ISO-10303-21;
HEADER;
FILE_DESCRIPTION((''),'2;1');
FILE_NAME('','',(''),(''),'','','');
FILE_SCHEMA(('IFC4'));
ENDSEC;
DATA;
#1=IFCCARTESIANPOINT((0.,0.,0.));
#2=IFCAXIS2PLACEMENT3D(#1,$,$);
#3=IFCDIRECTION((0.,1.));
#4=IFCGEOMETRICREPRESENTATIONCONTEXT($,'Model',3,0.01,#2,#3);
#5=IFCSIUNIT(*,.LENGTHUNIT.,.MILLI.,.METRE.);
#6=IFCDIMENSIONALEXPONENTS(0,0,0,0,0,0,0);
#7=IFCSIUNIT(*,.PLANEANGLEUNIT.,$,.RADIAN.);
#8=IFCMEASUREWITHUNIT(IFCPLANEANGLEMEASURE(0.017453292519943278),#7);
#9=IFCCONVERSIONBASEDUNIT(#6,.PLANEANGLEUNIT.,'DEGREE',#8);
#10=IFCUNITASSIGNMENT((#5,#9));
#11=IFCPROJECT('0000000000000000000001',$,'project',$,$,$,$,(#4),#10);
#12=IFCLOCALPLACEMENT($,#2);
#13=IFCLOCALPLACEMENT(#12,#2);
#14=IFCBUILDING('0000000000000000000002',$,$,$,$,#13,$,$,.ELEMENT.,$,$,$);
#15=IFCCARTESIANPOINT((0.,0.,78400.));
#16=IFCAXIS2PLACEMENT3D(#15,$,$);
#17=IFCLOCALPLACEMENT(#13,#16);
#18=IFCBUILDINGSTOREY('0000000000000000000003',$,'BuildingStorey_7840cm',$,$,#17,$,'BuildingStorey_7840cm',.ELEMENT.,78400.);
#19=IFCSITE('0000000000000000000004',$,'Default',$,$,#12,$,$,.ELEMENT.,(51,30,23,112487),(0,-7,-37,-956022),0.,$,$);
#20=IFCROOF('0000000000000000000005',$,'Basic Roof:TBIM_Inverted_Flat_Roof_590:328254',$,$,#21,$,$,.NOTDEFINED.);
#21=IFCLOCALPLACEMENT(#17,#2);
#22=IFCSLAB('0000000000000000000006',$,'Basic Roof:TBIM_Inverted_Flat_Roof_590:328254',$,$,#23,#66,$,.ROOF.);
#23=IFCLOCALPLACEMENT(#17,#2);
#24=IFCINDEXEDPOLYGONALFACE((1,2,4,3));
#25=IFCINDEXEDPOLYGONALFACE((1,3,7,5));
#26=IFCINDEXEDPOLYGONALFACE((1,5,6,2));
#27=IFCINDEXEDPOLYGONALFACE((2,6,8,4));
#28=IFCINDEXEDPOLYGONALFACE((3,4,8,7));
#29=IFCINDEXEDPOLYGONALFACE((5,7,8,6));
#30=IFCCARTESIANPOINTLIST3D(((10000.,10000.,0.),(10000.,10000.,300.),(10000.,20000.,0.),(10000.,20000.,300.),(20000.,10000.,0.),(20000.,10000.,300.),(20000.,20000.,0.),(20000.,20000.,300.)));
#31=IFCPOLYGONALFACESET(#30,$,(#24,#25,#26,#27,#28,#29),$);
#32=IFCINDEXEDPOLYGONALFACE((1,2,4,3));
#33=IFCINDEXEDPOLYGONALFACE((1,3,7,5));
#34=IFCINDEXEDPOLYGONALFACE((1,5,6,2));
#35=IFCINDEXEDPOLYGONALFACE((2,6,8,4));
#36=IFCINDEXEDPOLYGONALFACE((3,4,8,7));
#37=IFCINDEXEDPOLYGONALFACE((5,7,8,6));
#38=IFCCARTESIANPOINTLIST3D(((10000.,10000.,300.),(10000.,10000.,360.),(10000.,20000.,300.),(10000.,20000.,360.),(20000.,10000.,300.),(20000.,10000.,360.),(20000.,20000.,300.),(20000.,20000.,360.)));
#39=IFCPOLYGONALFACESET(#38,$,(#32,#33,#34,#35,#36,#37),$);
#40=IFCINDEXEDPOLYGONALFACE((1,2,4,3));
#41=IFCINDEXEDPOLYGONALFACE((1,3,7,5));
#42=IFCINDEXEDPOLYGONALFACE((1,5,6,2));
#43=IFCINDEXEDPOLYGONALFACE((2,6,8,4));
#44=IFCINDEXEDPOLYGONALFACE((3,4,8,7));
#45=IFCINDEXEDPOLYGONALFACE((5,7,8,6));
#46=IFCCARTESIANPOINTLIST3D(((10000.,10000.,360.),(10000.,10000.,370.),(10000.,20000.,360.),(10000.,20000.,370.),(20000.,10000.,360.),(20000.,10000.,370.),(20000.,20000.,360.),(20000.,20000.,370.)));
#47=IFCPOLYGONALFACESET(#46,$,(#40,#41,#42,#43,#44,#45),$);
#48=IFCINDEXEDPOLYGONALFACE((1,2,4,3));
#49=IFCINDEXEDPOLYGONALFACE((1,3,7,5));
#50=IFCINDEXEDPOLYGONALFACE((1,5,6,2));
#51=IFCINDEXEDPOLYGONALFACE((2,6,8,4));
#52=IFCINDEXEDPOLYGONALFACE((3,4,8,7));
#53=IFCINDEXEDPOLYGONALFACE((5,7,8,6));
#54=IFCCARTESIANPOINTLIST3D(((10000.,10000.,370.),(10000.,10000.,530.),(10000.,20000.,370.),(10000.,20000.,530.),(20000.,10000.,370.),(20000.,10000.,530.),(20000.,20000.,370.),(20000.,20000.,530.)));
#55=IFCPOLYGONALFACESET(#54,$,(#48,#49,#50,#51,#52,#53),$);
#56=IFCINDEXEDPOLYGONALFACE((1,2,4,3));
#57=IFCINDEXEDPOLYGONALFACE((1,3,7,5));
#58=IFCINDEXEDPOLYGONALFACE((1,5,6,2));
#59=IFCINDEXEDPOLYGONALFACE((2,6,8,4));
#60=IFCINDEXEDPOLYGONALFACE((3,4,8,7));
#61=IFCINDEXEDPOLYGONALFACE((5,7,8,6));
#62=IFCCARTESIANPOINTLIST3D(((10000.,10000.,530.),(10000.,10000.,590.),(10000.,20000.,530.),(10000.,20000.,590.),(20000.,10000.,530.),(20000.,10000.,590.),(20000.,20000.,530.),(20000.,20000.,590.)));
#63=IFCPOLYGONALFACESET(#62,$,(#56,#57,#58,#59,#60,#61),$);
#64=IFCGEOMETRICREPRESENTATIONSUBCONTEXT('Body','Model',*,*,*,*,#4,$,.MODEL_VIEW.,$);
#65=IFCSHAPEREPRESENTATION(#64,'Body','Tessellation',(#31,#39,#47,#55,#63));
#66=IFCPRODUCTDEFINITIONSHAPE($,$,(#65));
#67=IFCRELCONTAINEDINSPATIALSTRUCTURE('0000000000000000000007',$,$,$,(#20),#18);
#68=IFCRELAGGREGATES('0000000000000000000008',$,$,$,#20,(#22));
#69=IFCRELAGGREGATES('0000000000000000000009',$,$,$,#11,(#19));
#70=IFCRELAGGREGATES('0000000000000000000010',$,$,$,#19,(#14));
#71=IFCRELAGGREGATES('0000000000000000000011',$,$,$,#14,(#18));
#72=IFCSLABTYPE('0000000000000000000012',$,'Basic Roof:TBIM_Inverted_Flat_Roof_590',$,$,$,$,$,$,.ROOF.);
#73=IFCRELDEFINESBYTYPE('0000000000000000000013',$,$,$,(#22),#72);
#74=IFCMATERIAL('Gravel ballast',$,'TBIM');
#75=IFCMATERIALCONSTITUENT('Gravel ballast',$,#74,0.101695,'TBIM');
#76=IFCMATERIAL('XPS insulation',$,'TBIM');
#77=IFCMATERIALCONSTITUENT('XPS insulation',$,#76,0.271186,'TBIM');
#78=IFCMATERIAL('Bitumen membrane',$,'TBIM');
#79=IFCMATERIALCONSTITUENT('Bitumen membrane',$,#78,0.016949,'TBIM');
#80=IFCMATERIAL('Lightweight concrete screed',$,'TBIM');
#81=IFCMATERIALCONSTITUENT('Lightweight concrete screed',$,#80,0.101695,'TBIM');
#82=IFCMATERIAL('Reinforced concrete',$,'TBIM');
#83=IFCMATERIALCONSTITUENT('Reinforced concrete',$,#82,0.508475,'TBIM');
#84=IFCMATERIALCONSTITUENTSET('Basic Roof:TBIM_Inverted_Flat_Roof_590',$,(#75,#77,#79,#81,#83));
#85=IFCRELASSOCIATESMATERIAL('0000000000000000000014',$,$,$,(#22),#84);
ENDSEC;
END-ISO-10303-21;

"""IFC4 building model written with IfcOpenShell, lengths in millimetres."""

from ifc_helpers import new_model, entity, si_unit, converted_unit, direction, frame, origin, place, context, subcontext, project, spatial, indexed_curve, outline, extrude, material, constituent, constituent_set, type_object, element, aggregate, save


model = new_model("IFC4")

# Units and contexts
model_context = context("Model", 3, precision=0.01, world=origin(), true_north=direction((0.0, 1.0)))
body_context = subcontext(model_context, "Body", "Model", "MODEL_VIEW")
ifc_project = project(units=[si_unit("LENGTHUNIT", "METRE", prefix="MILLI"), converted_unit("PLANEANGLEUNIT", "DEGREE", entity("IfcPlaneAngleMeasure", 0.017453292519943278), si_unit("PLANEANGLEUNIT", "RADIAN"), dimensions=[0, 0, 0, 0, 0, 0, 0])], contexts=[model_context])

# Site, building, storey
site_placement = place(None, origin())
site = spatial("IfcSite", under=ifc_project, at=site_placement, Name="Default", CompositionType="ELEMENT", RefLatitude=(51, 30, 23, 112487), RefLongitude=(0, -7, -37, -956022), RefElevation=0.0)
building_placement = place(site_placement, origin())
building = spatial("IfcBuilding", under=site, at=building_placement, CompositionType="ELEMENT")
storey_placement = place(building_placement, frame((0.0, 0.0, 78400.0)))
storey = spatial("IfcBuildingStorey", under=building, at=storey_placement, Name="BuildingStorey_7840cm", LongName="BuildingStorey_7840cm", CompositionType="ELEMENT", Elevation=78400.0)

# Roof, slab
roof_placement = place(storey_placement, frame((10000.0, 10000.0, 0.0)))
roof = element("IfcRoof", 1, at=roof_placement, inside=storey, Name="Basic Roof:TBIM_Inverted_Flat_Roof_590:328254", PredefinedType="NOTDEFINED")
ifc_material_1 = material(Name="Gravel ballast", Category="TBIM")
ifc_constituent_1 = constituent(ifc_material_1, Name="Gravel ballast", Category="TBIM", fraction=0.101695)
ifc_material_2 = material(Name="XPS insulation", Category="TBIM")
ifc_constituent_2 = constituent(ifc_material_2, Name="XPS insulation", Category="TBIM", fraction=0.271186)
ifc_material_3 = material(Name="Bitumen membrane", Category="TBIM")
ifc_constituent_3 = constituent(ifc_material_3, Name="Bitumen membrane", Category="TBIM", fraction=0.016949)
ifc_material_4 = material(Name="Lightweight concrete screed", Category="TBIM")
ifc_constituent_4 = constituent(ifc_material_4, Name="Lightweight concrete screed", Category="TBIM", fraction=0.101695)
ifc_material_5 = material(Name="Reinforced concrete", Category="TBIM")
ifc_constituent_5 = constituent(ifc_material_5, Name="Reinforced concrete", Category="TBIM", fraction=0.508475)
ifc_constituent_set = constituent_set(constituents=[ifc_constituent_1, ifc_constituent_2, ifc_constituent_3, ifc_constituent_4, ifc_constituent_5], Name="Basic Roof:TBIM_Inverted_Flat_Roof_590")
slab_type = type_object("IfcSlabType", Name="Basic Roof:TBIM_Inverted_Flat_Roof_590", PredefinedType="ROOF")
slab_placement = place(roof_placement, origin())
slab = element("IfcSlab", 2, at=slab_placement, type_object=slab_type, material=ifc_constituent_set, Name="Basic Roof:TBIM_Inverted_Flat_Roof_590:328254", PredefinedType="ROOF", context=body_context, shape_type="SweptSolid", body=[
    extrude(outline(indexed_curve([(-5000.0, 5000.0), (-5000.0, -5000.0), (5000.0, -5000.0), (5000.0, 5000.0), (-5000.0, 5000.0)], self_intersect=False)), frame((5000.0, 5000.0, 0.0)), (0.0, 0.0, 1.0), 300.0),
    extrude(outline(indexed_curve([(-5000.0, 5000.0), (-5000.0, -5000.0), (5000.0, -5000.0), (5000.0, 5000.0), (-5000.0, 5000.0)], self_intersect=False)), frame((5000.0, 5000.0, 300.0)), (0.0, 0.0, 1.0), 60.0),
    extrude(outline(indexed_curve([(-5000.0, 5000.0), (-5000.0, -5000.0), (5000.0, -5000.0), (5000.0, 5000.0), (-5000.0, 5000.0)], self_intersect=False)), frame((5000.0, 5000.0, 360.0)), (0.0, 0.0, 1.0), 10.0),
    extrude(outline(indexed_curve([(-5000.0, 5000.0), (-5000.0, -5000.0), (5000.0, -5000.0), (5000.0, 5000.0), (-5000.0, 5000.0)], self_intersect=False)), frame((5000.0, 5000.0, 370.0)), (0.0, 0.0, 1.0), 160.0),
    extrude(outline(indexed_curve([(-5000.0, 5000.0), (-5000.0, -5000.0), (5000.0, -5000.0), (5000.0, 5000.0), (-5000.0, 5000.0)], self_intersect=False)), frame((5000.0, 5000.0, 530.0)), (0.0, 0.0, 1.0), 60.0),
])
aggregate(roof, [slab])

save(model, "model.ifc")
